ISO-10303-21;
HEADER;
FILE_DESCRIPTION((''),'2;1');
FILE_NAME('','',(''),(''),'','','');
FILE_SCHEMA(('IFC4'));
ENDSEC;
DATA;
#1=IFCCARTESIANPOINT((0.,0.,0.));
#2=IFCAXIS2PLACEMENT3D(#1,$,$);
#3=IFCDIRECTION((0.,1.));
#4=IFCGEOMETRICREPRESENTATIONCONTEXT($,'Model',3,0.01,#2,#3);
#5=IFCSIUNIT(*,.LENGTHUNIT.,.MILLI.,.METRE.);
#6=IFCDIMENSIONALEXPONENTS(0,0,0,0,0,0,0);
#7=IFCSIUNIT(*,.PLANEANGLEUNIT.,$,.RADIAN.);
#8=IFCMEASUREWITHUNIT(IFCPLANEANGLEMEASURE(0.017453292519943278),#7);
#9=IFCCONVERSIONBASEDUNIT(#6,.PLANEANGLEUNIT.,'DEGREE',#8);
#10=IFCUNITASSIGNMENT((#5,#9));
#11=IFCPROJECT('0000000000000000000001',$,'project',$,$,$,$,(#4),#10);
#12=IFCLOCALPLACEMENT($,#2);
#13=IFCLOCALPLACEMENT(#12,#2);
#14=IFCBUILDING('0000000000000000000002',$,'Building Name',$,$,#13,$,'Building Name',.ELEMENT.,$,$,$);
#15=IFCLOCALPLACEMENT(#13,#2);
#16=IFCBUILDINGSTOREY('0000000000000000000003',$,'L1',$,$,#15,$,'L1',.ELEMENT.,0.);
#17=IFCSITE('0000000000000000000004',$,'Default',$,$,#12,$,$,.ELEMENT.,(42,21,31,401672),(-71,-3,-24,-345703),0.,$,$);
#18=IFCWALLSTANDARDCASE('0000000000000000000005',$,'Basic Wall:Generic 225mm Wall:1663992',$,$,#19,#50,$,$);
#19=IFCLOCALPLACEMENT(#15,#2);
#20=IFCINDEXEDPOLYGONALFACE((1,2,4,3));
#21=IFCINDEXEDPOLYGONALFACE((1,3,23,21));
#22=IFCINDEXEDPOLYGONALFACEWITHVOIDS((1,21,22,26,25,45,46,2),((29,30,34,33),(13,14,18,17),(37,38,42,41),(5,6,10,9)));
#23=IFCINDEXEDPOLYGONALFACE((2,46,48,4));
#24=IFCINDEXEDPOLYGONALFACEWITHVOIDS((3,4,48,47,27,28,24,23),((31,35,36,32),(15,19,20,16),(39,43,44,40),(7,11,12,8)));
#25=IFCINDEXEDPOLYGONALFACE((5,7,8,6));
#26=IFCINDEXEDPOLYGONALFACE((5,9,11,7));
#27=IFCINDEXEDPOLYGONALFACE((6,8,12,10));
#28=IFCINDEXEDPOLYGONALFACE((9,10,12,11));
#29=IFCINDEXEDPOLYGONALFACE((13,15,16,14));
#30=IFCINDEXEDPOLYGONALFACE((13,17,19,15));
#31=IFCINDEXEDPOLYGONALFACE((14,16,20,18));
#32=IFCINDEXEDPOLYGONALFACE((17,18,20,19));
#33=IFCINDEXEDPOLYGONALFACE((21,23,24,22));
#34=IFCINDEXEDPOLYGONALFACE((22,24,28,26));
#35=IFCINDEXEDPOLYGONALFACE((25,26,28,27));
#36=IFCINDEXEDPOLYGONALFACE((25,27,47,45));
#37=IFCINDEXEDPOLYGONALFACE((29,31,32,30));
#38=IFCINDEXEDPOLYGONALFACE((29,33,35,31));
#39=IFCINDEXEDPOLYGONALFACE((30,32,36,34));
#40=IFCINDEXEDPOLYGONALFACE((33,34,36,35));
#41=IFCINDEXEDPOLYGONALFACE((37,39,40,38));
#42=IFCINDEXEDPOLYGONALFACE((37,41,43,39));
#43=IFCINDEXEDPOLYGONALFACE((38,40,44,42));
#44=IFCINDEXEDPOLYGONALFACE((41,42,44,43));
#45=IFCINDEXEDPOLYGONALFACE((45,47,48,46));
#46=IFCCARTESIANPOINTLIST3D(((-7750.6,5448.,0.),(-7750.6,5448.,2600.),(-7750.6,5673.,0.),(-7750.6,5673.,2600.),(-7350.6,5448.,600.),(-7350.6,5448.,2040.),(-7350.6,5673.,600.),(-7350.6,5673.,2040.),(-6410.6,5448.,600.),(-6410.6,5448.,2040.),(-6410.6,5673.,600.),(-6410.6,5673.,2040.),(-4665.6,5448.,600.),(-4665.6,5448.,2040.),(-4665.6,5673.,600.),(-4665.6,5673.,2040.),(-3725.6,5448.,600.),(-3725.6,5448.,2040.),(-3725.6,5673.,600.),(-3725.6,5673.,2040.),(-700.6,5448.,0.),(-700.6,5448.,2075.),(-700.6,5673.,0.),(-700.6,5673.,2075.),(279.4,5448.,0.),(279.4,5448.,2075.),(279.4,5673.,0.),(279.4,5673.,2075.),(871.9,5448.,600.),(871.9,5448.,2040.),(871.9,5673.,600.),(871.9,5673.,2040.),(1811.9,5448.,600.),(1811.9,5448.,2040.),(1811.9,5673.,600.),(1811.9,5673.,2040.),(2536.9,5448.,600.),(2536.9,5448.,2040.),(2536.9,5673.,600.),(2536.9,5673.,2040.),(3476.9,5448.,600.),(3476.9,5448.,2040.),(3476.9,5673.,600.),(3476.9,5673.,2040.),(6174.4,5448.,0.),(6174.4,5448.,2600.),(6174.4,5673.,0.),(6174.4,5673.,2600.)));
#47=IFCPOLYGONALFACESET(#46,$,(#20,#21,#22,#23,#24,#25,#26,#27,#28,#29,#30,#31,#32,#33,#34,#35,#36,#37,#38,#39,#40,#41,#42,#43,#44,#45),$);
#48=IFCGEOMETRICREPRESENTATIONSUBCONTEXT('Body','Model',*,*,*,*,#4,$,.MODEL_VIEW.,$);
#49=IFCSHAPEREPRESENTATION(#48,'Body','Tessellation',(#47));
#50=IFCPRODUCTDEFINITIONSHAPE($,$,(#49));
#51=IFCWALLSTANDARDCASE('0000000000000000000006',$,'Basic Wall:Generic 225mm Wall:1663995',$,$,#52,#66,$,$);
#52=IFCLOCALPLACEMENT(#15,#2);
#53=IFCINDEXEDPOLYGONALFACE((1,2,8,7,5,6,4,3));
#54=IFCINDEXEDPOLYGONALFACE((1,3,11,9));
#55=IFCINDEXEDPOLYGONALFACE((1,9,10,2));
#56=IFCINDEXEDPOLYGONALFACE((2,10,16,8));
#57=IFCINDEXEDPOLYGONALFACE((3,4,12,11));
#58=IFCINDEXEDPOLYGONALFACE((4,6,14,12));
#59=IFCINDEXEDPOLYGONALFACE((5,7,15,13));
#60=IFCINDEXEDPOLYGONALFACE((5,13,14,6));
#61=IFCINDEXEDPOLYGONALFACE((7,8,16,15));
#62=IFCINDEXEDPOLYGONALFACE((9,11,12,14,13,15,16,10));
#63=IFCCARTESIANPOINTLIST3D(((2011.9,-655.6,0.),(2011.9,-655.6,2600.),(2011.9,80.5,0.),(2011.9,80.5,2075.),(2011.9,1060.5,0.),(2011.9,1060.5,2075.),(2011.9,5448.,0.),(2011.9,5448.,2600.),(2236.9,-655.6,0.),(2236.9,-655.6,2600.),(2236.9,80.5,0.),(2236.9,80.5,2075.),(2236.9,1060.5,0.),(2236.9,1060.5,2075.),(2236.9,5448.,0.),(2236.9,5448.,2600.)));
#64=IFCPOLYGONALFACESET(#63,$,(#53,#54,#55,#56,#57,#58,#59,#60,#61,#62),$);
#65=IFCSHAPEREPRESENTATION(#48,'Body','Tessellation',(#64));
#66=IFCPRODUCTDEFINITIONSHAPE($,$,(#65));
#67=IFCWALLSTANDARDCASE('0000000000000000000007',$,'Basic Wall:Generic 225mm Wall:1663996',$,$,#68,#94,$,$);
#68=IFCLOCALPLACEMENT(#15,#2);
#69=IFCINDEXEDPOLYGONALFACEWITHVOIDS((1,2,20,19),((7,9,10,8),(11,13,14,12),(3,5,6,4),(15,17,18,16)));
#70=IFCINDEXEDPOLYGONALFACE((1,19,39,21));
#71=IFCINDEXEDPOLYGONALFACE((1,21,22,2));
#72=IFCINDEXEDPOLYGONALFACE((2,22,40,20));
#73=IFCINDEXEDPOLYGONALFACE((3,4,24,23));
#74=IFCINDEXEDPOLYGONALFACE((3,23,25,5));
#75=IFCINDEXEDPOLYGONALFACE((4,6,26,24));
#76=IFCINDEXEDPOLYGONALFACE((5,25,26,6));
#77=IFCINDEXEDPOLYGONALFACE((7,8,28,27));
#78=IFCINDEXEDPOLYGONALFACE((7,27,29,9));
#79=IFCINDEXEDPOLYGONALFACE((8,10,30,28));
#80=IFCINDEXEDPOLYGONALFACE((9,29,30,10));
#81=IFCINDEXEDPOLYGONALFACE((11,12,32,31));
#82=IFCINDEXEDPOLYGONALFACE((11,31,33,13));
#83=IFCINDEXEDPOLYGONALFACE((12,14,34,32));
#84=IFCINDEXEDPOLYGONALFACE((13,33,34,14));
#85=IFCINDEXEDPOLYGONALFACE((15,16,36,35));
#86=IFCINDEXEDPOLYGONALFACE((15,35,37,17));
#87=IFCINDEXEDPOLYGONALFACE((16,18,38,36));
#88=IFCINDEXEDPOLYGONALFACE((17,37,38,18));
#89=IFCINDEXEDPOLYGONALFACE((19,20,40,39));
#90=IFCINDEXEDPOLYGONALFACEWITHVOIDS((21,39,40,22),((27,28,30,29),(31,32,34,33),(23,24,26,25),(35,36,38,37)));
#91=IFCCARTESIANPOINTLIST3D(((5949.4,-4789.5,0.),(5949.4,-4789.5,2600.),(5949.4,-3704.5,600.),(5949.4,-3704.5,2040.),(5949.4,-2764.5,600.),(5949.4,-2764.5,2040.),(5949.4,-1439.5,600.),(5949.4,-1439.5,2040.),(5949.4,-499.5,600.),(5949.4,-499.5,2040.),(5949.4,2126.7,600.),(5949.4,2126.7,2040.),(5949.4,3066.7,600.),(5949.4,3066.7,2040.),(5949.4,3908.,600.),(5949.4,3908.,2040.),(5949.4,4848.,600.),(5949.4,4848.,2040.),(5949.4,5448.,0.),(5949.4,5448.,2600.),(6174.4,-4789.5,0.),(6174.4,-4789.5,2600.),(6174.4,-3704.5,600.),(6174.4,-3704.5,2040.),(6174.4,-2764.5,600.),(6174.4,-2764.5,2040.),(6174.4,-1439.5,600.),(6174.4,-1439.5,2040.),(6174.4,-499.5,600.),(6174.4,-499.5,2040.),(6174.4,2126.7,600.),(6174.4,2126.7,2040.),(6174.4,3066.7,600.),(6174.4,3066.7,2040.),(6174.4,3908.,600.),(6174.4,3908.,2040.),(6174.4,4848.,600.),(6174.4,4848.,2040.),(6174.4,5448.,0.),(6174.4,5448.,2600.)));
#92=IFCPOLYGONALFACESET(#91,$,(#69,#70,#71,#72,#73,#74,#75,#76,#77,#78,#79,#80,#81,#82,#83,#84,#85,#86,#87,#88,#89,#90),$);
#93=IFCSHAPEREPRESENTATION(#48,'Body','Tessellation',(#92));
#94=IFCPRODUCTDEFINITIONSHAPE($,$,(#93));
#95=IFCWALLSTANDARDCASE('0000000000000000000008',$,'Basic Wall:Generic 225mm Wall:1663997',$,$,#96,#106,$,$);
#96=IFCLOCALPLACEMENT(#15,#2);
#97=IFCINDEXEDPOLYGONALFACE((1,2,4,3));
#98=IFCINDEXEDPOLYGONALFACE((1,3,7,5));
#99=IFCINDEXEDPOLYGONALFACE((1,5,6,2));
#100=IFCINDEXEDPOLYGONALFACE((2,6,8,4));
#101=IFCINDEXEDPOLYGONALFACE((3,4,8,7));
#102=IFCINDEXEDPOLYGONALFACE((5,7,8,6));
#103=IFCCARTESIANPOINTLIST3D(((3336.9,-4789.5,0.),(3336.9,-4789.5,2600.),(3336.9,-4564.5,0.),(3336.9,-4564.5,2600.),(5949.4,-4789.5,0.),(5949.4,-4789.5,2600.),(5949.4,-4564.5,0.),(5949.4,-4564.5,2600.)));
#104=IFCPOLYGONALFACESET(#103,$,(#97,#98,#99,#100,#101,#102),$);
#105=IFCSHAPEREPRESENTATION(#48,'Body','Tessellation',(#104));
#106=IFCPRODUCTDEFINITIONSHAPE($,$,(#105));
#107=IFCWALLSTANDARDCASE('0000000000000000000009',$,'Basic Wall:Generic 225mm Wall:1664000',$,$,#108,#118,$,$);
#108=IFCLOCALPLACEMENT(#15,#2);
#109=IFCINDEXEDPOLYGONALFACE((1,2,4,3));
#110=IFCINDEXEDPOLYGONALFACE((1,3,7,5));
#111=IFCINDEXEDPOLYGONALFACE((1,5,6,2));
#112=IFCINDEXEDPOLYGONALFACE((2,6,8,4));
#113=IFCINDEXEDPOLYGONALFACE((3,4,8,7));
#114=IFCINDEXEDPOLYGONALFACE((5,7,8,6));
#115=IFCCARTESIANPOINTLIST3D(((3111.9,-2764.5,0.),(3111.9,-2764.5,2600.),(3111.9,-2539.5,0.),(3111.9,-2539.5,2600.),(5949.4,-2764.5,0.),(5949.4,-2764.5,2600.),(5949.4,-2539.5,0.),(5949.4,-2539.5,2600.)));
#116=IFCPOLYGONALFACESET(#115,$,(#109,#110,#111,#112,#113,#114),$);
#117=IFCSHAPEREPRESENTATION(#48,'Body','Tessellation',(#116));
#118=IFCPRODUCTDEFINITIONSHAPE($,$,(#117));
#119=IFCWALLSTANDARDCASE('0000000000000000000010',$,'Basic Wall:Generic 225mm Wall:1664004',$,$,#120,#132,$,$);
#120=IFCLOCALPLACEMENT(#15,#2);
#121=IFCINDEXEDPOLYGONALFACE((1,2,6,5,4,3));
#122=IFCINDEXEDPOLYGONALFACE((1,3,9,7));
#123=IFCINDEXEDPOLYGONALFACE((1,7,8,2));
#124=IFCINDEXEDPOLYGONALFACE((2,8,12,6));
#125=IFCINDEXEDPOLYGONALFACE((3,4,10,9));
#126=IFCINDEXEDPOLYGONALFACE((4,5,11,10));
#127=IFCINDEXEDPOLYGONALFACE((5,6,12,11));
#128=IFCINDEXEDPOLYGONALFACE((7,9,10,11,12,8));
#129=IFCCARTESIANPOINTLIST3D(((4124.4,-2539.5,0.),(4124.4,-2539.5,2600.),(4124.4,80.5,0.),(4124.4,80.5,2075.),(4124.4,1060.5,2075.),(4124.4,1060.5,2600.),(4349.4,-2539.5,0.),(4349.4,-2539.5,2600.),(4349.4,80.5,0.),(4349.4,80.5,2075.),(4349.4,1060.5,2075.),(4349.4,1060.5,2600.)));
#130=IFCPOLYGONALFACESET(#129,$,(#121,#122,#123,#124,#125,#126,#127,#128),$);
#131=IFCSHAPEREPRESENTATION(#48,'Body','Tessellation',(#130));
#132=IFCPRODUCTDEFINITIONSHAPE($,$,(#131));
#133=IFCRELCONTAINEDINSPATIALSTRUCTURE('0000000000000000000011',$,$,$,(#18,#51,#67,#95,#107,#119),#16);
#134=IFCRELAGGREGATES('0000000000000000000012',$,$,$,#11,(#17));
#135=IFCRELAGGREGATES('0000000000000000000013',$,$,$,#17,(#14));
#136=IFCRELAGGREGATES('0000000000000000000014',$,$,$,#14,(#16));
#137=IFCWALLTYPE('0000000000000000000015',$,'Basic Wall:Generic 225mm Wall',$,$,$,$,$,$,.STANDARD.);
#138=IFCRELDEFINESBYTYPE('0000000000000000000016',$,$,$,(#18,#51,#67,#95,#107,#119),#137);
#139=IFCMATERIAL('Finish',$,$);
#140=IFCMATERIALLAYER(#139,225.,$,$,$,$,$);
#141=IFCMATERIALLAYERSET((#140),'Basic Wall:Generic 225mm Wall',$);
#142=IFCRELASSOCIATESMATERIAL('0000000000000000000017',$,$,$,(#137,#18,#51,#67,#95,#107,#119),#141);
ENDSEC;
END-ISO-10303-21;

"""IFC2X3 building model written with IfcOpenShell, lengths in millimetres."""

from ifc_helpers import new_model, entity, si_unit, converted_unit, direction, frame, frame_2d, origin, place, context, subcontext, project, spatial, rectangle, extrude, material, layer, layer_set, layer_usage, type_object, element, save


model = new_model("IFC2X3")

# Units and contexts
model_context = context("Model", 3, precision=0.01, world=origin(), true_north=direction((0.0, 1.0)))
body_context = subcontext(model_context, "Body", "Model", "MODEL_VIEW")
ifc_project = project(units=[si_unit("LENGTHUNIT", "METRE", prefix="MILLI"), converted_unit("PLANEANGLEUNIT", "DEGREE", entity("IfcPlaneAngleMeasure", 0.017453292519943278), si_unit("PLANEANGLEUNIT", "RADIAN"), dimensions=[0, 0, 0, 0, 0, 0, 0])], contexts=[model_context])

# Site, building, storey
site_placement = place(None, origin())
site = spatial("IfcSite", under=ifc_project, at=site_placement, Name="Default", CompositionType="ELEMENT", RefLatitude=(42, 21, 31, 401672), RefLongitude=(-71, -3, -24, -345703), RefElevation=0.0)
building_placement = place(site_placement, origin())
building = spatial("IfcBuilding", under=site, at=building_placement, Name="Building Name", LongName="Building Name", CompositionType="ELEMENT")
storey_placement = place(building_placement, origin())
storey = spatial("IfcBuildingStorey", under=building, at=storey_placement, Name="L1", LongName="L1", CompositionType="ELEMENT", Elevation=0.0)

# Wall, openings
ifc_material_1 = material(Name="Finish")
ifc_layer = layer(ifc_material_1, 225.0)
ifc_layer_set = layer_set([ifc_layer], Name="Basic Wall:Generic 225mm Wall")
ifc_layer_usage_1 = layer_usage(ifc_layer_set, "AXIS2", "NEGATIVE", 112.5)
wall_type = type_object("IfcWallType", Name="Basic Wall:Generic 225mm Wall", PredefinedType="STANDARD", material=ifc_layer_set)
wall_1_placement = place(storey_placement, frame((6174.4, 5560.5, 0.0), z_axis=(0.0, 0.0, 1.0), x_axis=(-1.0, 0.0, 0.0)))
wall_1 = element("IfcWallStandardCase", 1, at=wall_1_placement, inside=storey, type_object=wall_type, material=ifc_layer_usage_1, Name="Basic Wall:Generic 225mm Wall:1663992", context=body_context, shape_type="SweptSolid", body=[
    extrude(rectangle(XDim=13925.0, YDim=225.0, at=frame_2d((6962.5, 0.0), x_axis=(-1.0, 0.0))), origin(), (0.0, 0.0, 1.0), 2600.0),
])
opening_1_placement = place(wall_1_placement, origin())
element("IfcOpeningElement", 2, at=opening_1_placement, cuts=wall_1, ObjectType="Opening", context=body_context, shape_type="SweptSolid", body=[
    extrude(rectangle(XDim=1440.0, YDim=940.0, at=frame_2d((0.0, 0.0), x_axis=(0.0, 1.0))), frame((3167.5, -112.5, 1320.0), z_axis=(0.0, 1.0, 0.0), x_axis=(-1.0, 0.0, 0.0)), (0.0, 0.0, 1.0), 225.0),
])
opening_2_placement = place(wall_1_placement, origin())
element("IfcOpeningElement", 3, at=opening_2_placement, cuts=wall_1, ObjectType="Opening", context=body_context, shape_type="SweptSolid", body=[
    extrude(rectangle(XDim=1440.0, YDim=940.0, at=frame_2d((0.0, 0.0), x_axis=(0.0, 1.0))), frame((4832.5, -112.5, 1320.0), z_axis=(0.0, 1.0, 0.0), x_axis=(1.0, 0.0, 0.0)), (0.0, 0.0, 1.0), 225.0),
])
opening_3_placement = place(wall_1_placement, origin())
element("IfcOpeningElement", 4, at=opening_3_placement, cuts=wall_1, ObjectType="Opening", context=body_context, shape_type="SweptSolid", body=[
    extrude(rectangle(XDim=1440.0, YDim=940.0, at=frame_2d((0.0, 0.0), x_axis=(0.0, 1.0))), frame((10370.0, -112.5, 1320.0), z_axis=(0.0, 1.0, 0.0), x_axis=(-1.0, 0.0, 0.0)), (0.0, 0.0, 1.0), 225.0),
])
opening_4_placement = place(wall_1_placement, origin())
element("IfcOpeningElement", 5, at=opening_4_placement, cuts=wall_1, ObjectType="Opening", context=body_context, shape_type="SweptSolid", body=[
    extrude(rectangle(XDim=1440.0, YDim=940.0, at=frame_2d((0.0, 0.0), x_axis=(0.0, 1.0))), frame((13055.0, -112.5, 1320.0), z_axis=(0.0, 1.0, 0.0), x_axis=(-1.0, 0.0, 0.0)), (0.0, 0.0, 1.0), 225.0),
])
opening_5_placement = place(wall_1_placement, frame((5895.0, -112.5, 0.0)))
element("IfcOpeningElement", 6, at=opening_5_placement, cuts=wall_1, ObjectType="Opening", context=body_context, shape_type="SweptSolid", body=[
    extrude(rectangle(XDim=980.0, YDim=2075.0, at=frame_2d((1037.5, 490.0), x_axis=(0.0, -1.0))), frame((0.0, 0.0, 0.0), z_axis=(0.0, 1.0, 0.0), x_axis=(0.0, 0.0, 1.0)), (0.0, 0.0, 1.0), 225.0),
])

# Wall, opening
ifc_layer_usage_2 = layer_usage(ifc_layer_set, "AXIS2", "NEGATIVE", 112.5)
wall_2_placement = place(storey_placement, frame((2124.4, 5448.0, 0.0), z_axis=(0.0, 0.0, 1.0), x_axis=(0.0, -1.0, 0.0)))
wall_2 = element("IfcWallStandardCase", 7, at=wall_2_placement, inside=storey, type_object=wall_type, material=ifc_layer_usage_2, Name="Basic Wall:Generic 225mm Wall:1663995", context=body_context, shape_type="SweptSolid", body=[
    extrude(rectangle(XDim=6103.6, YDim=225.0, at=frame_2d((3051.8, 0.0), x_axis=(-1.0, 0.0))), origin(), (0.0, 0.0, 1.0), 2600.0),
])
opening_6_placement = place(wall_2_placement, frame((5367.5, 112.5, 0.0)))
element("IfcOpeningElement", 8, at=opening_6_placement, cuts=wall_2, ObjectType="Opening", context=body_context, shape_type="SweptSolid", body=[
    extrude(rectangle(XDim=980.0, YDim=2075.0, at=frame_2d((1037.5, 490.0), x_axis=(0.0, -1.0))), frame((0.0, 0.0, 0.0), z_axis=(0.0, -1.0, 0.0), x_axis=(0.0, 0.0, 1.0)), (0.0, 0.0, 1.0), 225.0),
])

# Wall, openings
ifc_layer_usage_3 = layer_usage(ifc_layer_set, "AXIS2", "NEGATIVE", 112.5)
wall_3_placement = place(storey_placement, frame((6061.9, -4789.5, 0.0), z_axis=(0.0, 0.0, 1.0), x_axis=(0.0, 1.0, 0.0)))
wall_3 = element("IfcWallStandardCase", 9, at=wall_3_placement, inside=storey, type_object=wall_type, material=ifc_layer_usage_3, Name="Basic Wall:Generic 225mm Wall:1663996", context=body_context, shape_type="SweptSolid", body=[
    extrude(rectangle(XDim=10237.5, YDim=225.0, at=frame_2d((5118.8, 0.0), x_axis=(-1.0, 0.0))), origin(), (0.0, 0.0, 1.0), 2600.0),
])
opening_7_placement = place(wall_3_placement, origin())
element("IfcOpeningElement", 10, at=opening_7_placement, cuts=wall_3, ObjectType="Opening", context=body_context, shape_type="SweptSolid", body=[
    extrude(rectangle(XDim=1440.0, YDim=940.0, at=frame_2d((0.0, 0.0), x_axis=(0.0, 1.0))), frame((1555.0, -112.5, 1320.0), z_axis=(0.0, 1.0, 0.0), x_axis=(1.0, 0.0, 0.0)), (0.0, 0.0, 1.0), 225.0),
])
opening_8_placement = place(wall_3_placement, origin())
element("IfcOpeningElement", 11, at=opening_8_placement, cuts=wall_3, ObjectType="Opening", context=body_context, shape_type="SweptSolid", body=[
    extrude(rectangle(XDim=1440.0, YDim=940.0, at=frame_2d((0.0, 0.0), x_axis=(0.0, 1.0))), frame((3820.0, -112.5, 1320.0), z_axis=(0.0, 1.0, 0.0), x_axis=(1.0, 0.0, 0.0)), (0.0, 0.0, 1.0), 225.0),
])
opening_9_placement = place(wall_3_placement, origin())
element("IfcOpeningElement", 12, at=opening_9_placement, cuts=wall_3, ObjectType="Opening", context=body_context, shape_type="SweptSolid", body=[
    extrude(rectangle(XDim=1440.0, YDim=940.0, at=frame_2d((0.0, 0.0), x_axis=(0.0, 1.0))), frame((7386.3, -112.5, 1320.0), z_axis=(0.0, 1.0, 0.0), x_axis=(1.0, 0.0, 0.0)), (0.0, 0.0, 1.0), 225.0),
])
opening_10_placement = place(wall_3_placement, origin())
element("IfcOpeningElement", 13, at=opening_10_placement, cuts=wall_3, ObjectType="Opening", context=body_context, shape_type="SweptSolid", body=[
    extrude(rectangle(XDim=1440.0, YDim=940.0, at=frame_2d((0.0, 0.0), x_axis=(0.0, 1.0))), frame((9167.5, -112.5, 1320.0), z_axis=(0.0, 1.0, 0.0), x_axis=(-1.0, 0.0, 0.0)), (0.0, 0.0, 1.0), 225.0),
])

# Walls
ifc_layer_usage_4 = layer_usage(ifc_layer_set, "AXIS2", "NEGATIVE", 112.5)
wall_4_placement = place(storey_placement, frame((5949.4, -4677.0, 0.0), z_axis=(0.0, 0.0, 1.0), x_axis=(-1.0, 0.0, 0.0)))
element("IfcWallStandardCase", 14, at=wall_4_placement, inside=storey, type_object=wall_type, material=ifc_layer_usage_4, Name="Basic Wall:Generic 225mm Wall:1663997", context=body_context, shape_type="SweptSolid", body=[
    extrude(rectangle(XDim=2612.5, YDim=225.0, at=frame_2d((1306.3, 0.0), x_axis=(-1.0, 0.0))), origin(), (0.0, 0.0, 1.0), 2600.0),
])
ifc_layer_usage_5 = layer_usage(ifc_layer_set, "AXIS2", "NEGATIVE", 112.5)
wall_5_placement = place(storey_placement, frame((3111.9, -2652.0, 0.0)))
element("IfcWallStandardCase", 15, at=wall_5_placement, inside=storey, type_object=wall_type, material=ifc_layer_usage_5, Name="Basic Wall:Generic 225mm Wall:1664000", context=body_context, shape_type="SweptSolid", body=[
    extrude(rectangle(XDim=2837.5, YDim=225.0, at=frame_2d((1418.8, 0.0), x_axis=(-1.0, 0.0))), origin(), (0.0, 0.0, 1.0), 2600.0),
])

# Wall, opening
ifc_layer_usage_6 = layer_usage(ifc_layer_set, "AXIS2", "NEGATIVE", 112.5)
wall_6_placement = place(storey_placement, frame((4236.9, -2539.5, 0.0), z_axis=(0.0, 0.0, 1.0), x_axis=(0.0, 1.0, 0.0)))
wall_6 = element("IfcWallStandardCase", 16, at=wall_6_placement, inside=storey, type_object=wall_type, material=ifc_layer_usage_6, Name="Basic Wall:Generic 225mm Wall:1664004", context=body_context, shape_type="SweptSolid", body=[
    extrude(rectangle(XDim=3600.0, YDim=225.0, at=frame_2d((1800.0, 0.0), x_axis=(-1.0, 0.0))), origin(), (0.0, 0.0, 1.0), 2600.0),
])
opening_11_placement = place(wall_6_placement, frame((2620.0, -112.5, 0.0)))
element("IfcOpeningElement", 17, at=opening_11_placement, cuts=wall_6, ObjectType="Opening", context=body_context, shape_type="SweptSolid", body=[
    extrude(rectangle(XDim=980.0, YDim=2075.0, at=frame_2d((1037.5, 490.0), x_axis=(0.0, -1.0))), frame((0.0, 0.0, 0.0), z_axis=(0.0, 1.0, 0.0), x_axis=(0.0, 0.0, 1.0)), (0.0, 0.0, 1.0), 225.0),
])

save(model, "model.ifc")
